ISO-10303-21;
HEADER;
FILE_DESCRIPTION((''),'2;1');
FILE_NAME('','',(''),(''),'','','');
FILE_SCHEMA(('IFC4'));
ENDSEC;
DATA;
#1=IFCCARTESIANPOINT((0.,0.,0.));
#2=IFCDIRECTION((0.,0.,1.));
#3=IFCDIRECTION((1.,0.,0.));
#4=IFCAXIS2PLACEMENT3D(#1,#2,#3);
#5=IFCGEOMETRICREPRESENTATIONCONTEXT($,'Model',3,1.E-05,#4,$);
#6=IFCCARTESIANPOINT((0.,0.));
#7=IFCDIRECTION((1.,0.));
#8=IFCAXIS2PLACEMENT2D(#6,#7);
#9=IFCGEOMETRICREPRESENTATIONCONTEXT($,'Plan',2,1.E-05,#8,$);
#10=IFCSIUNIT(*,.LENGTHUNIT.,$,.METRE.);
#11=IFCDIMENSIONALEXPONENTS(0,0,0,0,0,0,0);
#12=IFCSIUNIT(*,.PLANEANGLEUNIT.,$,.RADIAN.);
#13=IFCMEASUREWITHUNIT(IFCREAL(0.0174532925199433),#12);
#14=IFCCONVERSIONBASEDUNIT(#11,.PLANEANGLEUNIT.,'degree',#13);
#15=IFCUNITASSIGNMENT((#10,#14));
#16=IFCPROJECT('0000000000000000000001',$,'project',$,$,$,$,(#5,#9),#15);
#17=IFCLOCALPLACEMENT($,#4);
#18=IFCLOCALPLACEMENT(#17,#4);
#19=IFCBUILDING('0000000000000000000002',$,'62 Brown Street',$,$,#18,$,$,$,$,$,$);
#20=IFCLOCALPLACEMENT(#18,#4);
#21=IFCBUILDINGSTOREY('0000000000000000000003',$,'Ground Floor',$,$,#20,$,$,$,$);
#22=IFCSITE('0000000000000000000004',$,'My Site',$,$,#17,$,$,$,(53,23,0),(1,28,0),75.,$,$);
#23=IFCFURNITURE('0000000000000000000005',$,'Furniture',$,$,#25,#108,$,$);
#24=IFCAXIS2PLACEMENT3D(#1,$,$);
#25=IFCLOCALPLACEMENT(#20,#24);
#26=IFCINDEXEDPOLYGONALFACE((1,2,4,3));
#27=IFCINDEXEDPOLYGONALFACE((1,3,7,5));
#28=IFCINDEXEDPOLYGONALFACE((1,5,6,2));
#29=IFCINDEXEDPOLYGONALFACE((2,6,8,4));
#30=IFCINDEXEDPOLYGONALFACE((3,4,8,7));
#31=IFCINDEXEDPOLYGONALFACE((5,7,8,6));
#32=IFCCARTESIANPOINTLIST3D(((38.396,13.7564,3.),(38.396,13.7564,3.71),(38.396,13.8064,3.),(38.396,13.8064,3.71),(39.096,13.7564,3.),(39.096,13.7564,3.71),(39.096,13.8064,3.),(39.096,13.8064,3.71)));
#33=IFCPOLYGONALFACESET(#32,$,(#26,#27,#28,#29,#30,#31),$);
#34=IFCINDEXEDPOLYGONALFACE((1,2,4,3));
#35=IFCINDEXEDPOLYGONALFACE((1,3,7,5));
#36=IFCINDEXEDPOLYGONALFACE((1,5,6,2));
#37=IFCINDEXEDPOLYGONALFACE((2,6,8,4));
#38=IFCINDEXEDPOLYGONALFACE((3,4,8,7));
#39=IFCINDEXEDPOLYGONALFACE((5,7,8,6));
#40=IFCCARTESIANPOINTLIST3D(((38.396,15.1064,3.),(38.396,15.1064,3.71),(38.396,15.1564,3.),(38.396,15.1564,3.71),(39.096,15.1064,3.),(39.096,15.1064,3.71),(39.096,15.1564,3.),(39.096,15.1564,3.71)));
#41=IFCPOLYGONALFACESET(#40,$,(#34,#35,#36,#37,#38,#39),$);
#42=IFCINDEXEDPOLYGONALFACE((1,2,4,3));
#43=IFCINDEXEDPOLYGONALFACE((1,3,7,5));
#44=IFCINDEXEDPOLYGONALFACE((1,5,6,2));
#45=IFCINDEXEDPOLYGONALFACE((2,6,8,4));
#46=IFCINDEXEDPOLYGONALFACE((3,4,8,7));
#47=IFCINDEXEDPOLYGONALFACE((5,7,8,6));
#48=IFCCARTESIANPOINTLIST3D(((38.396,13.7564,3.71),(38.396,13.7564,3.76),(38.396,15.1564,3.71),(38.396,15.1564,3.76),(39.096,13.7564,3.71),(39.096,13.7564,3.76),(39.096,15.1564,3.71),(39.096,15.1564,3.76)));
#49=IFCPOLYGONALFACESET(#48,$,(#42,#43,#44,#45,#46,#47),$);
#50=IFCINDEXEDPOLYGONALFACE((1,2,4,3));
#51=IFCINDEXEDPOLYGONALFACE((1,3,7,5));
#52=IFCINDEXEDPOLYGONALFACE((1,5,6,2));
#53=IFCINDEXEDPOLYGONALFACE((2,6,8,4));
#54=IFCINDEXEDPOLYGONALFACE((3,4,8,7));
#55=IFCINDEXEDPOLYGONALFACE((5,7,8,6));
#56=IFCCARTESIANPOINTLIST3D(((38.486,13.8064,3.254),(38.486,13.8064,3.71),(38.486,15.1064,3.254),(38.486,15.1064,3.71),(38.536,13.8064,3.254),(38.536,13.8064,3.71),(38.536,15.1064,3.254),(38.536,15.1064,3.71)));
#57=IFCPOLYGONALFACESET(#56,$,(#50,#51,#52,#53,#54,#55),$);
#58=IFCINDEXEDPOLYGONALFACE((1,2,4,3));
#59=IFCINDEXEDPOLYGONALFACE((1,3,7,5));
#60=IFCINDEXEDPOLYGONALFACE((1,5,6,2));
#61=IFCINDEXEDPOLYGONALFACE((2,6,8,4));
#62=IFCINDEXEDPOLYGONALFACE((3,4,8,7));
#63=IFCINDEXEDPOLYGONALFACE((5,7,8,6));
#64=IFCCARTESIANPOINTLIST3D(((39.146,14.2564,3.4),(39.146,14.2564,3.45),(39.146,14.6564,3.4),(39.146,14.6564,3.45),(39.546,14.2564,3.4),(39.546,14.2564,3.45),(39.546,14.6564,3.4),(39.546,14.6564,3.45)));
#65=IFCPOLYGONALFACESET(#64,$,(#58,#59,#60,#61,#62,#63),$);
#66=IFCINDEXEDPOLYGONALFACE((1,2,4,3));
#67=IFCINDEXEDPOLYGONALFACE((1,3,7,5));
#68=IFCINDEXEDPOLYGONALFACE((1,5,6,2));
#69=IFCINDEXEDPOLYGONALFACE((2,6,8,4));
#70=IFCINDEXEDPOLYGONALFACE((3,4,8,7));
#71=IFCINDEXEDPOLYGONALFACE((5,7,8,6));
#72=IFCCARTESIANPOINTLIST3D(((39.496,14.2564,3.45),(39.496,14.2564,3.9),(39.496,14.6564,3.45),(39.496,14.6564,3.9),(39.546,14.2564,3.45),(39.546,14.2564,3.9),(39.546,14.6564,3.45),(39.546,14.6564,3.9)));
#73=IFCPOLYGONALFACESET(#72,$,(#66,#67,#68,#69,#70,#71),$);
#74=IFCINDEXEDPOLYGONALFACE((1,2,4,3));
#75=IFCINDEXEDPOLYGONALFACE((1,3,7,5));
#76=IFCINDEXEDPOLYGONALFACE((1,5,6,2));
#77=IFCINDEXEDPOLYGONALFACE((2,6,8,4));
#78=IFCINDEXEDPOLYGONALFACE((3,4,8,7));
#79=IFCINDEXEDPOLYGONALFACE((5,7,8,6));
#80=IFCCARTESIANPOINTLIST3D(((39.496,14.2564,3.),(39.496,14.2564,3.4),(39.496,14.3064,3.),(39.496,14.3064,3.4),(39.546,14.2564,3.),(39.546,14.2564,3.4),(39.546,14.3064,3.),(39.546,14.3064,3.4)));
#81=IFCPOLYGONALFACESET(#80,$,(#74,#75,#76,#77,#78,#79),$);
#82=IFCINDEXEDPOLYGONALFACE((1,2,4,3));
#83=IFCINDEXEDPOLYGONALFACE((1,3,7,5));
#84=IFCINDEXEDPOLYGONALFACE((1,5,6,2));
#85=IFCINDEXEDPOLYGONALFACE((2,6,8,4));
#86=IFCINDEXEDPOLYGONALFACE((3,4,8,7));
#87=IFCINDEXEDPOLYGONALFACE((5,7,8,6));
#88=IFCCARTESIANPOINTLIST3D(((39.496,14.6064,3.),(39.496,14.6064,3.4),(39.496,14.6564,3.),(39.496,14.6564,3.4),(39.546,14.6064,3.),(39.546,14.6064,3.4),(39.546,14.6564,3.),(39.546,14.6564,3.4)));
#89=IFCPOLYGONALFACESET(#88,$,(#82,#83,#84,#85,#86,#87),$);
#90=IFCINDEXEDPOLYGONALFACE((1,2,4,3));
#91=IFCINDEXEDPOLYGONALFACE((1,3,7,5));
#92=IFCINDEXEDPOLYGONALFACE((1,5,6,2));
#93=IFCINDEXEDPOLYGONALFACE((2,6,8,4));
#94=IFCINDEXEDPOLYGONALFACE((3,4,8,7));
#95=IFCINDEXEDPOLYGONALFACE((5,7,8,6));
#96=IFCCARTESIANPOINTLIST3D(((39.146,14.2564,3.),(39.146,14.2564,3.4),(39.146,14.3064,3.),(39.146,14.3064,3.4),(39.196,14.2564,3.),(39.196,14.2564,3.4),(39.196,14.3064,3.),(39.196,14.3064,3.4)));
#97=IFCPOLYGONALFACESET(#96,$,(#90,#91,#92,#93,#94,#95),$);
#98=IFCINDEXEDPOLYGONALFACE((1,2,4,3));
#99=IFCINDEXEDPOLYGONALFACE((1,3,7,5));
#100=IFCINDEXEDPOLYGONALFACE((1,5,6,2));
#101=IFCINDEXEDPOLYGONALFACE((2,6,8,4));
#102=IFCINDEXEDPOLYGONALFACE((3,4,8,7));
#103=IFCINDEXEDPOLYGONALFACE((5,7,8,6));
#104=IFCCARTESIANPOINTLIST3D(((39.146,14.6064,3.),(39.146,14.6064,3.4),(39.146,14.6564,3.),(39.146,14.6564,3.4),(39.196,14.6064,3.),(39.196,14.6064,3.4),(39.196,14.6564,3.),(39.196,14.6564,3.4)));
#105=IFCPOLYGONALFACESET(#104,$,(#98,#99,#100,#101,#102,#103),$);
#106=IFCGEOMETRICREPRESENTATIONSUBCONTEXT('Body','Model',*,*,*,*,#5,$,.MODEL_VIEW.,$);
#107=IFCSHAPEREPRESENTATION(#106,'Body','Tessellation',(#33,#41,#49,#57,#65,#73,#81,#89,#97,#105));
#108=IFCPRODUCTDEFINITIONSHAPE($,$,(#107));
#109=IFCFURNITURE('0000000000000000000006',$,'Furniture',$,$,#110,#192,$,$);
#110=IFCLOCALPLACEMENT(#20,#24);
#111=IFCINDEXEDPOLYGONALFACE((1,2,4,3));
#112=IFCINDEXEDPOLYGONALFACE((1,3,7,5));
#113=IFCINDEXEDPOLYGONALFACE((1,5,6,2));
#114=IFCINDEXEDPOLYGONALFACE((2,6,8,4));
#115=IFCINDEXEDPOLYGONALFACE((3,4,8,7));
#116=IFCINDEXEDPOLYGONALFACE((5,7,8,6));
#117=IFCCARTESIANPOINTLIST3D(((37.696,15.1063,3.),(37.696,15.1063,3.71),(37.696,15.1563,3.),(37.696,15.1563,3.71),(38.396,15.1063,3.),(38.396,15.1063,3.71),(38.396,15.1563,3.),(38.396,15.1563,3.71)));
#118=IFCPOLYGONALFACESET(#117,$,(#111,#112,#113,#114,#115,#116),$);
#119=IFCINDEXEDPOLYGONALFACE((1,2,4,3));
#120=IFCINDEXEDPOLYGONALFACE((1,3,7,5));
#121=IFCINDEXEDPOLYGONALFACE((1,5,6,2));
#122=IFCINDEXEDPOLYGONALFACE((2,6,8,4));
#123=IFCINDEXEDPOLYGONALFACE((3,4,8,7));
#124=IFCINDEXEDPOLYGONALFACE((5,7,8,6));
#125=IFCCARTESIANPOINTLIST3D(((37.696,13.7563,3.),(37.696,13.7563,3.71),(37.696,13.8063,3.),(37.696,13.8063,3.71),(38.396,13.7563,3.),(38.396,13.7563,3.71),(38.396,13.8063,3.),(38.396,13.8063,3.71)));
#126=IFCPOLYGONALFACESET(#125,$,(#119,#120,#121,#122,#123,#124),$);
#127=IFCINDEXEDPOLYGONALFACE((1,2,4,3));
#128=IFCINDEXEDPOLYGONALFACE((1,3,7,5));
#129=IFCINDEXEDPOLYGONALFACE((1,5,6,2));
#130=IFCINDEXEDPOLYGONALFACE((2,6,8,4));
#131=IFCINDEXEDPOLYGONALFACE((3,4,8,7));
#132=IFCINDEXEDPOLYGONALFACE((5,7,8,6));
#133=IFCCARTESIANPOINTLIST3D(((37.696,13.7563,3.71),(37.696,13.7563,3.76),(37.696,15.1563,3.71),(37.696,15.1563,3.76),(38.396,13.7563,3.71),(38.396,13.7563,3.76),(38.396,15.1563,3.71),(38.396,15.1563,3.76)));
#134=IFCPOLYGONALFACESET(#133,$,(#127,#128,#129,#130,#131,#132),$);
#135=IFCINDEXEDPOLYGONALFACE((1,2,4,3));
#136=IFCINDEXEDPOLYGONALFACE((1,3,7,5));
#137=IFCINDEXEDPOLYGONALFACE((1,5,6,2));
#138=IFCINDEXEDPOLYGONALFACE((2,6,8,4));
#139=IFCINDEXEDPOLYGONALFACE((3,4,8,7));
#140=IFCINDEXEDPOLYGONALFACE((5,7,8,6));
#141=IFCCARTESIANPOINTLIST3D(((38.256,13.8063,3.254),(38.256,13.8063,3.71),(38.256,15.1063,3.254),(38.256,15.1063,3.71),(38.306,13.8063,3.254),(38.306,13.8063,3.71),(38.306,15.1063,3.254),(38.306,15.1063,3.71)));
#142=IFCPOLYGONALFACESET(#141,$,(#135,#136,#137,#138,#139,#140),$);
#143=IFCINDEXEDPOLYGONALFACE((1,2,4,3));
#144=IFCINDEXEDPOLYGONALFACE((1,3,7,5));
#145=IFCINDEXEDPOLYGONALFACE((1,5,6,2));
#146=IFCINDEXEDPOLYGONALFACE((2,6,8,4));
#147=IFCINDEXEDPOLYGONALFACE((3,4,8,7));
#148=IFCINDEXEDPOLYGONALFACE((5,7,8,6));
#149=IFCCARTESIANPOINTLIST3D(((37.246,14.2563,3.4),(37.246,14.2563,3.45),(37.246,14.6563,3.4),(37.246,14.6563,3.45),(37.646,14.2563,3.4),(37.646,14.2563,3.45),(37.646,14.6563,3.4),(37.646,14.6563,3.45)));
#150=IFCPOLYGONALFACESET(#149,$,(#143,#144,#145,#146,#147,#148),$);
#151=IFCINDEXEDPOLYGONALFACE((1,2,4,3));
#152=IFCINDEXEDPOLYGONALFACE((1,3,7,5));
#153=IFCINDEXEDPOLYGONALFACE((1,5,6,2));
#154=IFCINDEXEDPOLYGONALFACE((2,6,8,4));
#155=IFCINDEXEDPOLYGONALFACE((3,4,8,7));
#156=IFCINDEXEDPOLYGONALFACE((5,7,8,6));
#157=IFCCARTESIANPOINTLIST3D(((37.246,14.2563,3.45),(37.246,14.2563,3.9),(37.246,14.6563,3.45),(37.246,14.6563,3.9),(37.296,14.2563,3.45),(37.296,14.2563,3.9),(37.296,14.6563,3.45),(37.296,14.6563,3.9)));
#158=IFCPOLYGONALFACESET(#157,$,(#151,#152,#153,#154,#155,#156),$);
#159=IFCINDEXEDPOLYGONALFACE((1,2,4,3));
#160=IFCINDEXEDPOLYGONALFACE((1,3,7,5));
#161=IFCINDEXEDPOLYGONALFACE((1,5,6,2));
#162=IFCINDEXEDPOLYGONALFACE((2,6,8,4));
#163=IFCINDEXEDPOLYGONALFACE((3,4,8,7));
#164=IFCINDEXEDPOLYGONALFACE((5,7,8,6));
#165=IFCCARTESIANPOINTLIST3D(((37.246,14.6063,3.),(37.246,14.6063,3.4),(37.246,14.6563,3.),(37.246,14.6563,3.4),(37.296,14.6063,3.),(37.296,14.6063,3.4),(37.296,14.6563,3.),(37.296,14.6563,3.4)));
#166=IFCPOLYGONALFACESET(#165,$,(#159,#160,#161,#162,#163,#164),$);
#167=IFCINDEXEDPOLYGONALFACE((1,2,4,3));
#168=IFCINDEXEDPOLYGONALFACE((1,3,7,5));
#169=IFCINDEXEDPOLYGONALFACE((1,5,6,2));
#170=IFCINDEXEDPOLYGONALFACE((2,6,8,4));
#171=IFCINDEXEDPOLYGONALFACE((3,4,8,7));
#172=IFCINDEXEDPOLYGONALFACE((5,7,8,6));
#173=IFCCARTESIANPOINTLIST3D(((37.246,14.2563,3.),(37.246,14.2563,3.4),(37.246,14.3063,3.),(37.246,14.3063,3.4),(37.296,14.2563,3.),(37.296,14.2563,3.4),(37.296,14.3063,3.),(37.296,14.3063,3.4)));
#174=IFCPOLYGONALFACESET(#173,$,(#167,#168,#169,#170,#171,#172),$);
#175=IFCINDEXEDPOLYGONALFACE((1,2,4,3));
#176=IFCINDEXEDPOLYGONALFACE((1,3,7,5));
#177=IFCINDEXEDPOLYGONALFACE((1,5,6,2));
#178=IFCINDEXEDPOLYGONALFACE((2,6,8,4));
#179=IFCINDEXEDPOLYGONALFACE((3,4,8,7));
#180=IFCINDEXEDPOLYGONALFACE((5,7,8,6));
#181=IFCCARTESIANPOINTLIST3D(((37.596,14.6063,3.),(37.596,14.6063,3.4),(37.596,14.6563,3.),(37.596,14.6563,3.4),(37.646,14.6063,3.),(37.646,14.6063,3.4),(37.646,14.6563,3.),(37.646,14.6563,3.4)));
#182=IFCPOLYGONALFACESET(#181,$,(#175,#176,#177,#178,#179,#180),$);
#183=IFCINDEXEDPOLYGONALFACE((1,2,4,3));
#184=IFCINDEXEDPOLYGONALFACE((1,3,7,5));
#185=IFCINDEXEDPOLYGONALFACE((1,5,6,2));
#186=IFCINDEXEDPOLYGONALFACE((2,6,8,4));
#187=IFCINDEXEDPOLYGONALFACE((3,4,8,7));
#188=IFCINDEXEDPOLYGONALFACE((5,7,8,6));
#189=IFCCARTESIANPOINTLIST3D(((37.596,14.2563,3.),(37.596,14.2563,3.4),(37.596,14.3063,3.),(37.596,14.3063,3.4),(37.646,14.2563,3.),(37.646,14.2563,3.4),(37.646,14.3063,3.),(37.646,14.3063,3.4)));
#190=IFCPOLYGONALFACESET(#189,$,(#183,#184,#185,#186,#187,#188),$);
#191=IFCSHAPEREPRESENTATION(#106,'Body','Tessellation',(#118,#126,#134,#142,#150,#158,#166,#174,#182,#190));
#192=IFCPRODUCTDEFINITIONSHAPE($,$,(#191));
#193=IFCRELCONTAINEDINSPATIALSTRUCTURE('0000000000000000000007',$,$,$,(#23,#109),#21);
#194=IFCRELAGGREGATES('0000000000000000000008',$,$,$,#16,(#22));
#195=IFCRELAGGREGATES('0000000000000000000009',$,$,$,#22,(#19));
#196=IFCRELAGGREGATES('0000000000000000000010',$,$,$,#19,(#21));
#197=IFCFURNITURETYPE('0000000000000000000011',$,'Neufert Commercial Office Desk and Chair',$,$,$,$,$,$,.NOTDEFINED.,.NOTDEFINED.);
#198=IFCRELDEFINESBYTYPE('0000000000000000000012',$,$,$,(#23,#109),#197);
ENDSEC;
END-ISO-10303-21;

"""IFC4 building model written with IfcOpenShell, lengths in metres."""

from ifc_helpers import new_model, entity, si_unit, converted_unit, frame, origin_with_axes, origin_2d_with_axis, place, context, subcontext, project, spatial, line, indexed_curve, outline, extrude, shape, source, transform, mapped, type_object, type_shapes, element, save


model = new_model("IFC4")

# Units and contexts
model_context = context("Model", 3, precision=1e-05, world=origin_with_axes())
plan_context = context("Plan", 2, precision=1e-05, world=origin_2d_with_axis())
body_context_1 = subcontext(model_context, "Body", "Model", "MODEL_VIEW")
body_context_2 = subcontext(plan_context, "Body", "Plan", "PLAN_VIEW")
ifc_project = project(units=[si_unit("LENGTHUNIT", "METRE"), converted_unit("PLANEANGLEUNIT", "degree", entity("IfcReal", 0.0174532925199433), si_unit("PLANEANGLEUNIT", "RADIAN"), dimensions=[0, 0, 0, 0, 0, 0, 0])], contexts=[model_context, plan_context])

# Site, building, storey
site_placement = place(None, origin_with_axes())
site = spatial("IfcSite", under=ifc_project, at=site_placement, Name="My Site", RefLatitude=(53, 23, 0), RefLongitude=(1, 28, 0), RefElevation=75.0)
building_placement = place(site_placement, origin_with_axes())
building = spatial("IfcBuilding", under=site, at=building_placement, Name="62 Brown Street")
storey_placement = place(building_placement, origin_with_axes())
storey = spatial("IfcBuildingStorey", under=building, at=storey_placement, Name="Ground Floor")

# Furniture
furniture_type = type_object("IfcFurnitureType", Name="Neufert Commercial Office Desk and Chair", AssemblyPlace="NOTDEFINED", PredefinedType="NOTDEFINED")
shared_shape_1 = source(origin_with_axes(), body_context_1, "Body", "SweptSolid", [
    extrude(outline(indexed_curve([(0.0, 0.0), (0.05, 0.0), (0.05, 0.7), (0.0, 0.7)], segments=[line(1, 2, 3, 4, 1)])), frame((0.0, 0.45, 0.0), z_axis=(0.0, 0.0, 1.0), x_axis=(1.0, 0.0, 0.0)), (0.0, 0.0, 1.0), 0.71),
    extrude(outline(indexed_curve([(0.0, 0.0), (0.05, 0.0), (0.05, 0.7), (0.0, 0.7)], segments=[line(1, 2, 3, 4, 1)])), frame((1.35, 0.45, 0.0), z_axis=(0.0, 0.0, 1.0), x_axis=(1.0, 0.0, 0.0)), (0.0, 0.0, 1.0), 0.71),
    extrude(outline(indexed_curve([(0.0, 0.0), (1.4, 0.0), (1.4, 0.7), (0.0, 0.7)], segments=[line(1, 2, 3, 4, 1)])), frame((0.0, 0.45, 0.71), z_axis=(0.0, 0.0, 1.0), x_axis=(1.0, 0.0, 0.0)), (0.0, 0.0, 1.0), 0.05),
    extrude(outline(indexed_curve([(0.05, 0.56), (1.35, 0.56), (1.35, 0.61), (0.05, 0.61)], segments=[line(1, 2, 3, 4, 1)])), frame((0.0, 0.45, 0.254), z_axis=(0.0, 0.0, 1.0), x_axis=(1.0, 0.0, 0.0)), (0.0, 0.0, 1.0), 0.456),
    extrude(outline(indexed_curve([(-0.2, 0.0), (0.2, 0.0), (0.2, 0.4), (-0.2, 0.4)], segments=[line(1, 2, 3, 4, 1)])), frame((0.7, 0.0, 0.45), z_axis=(0.0, 0.0, 1.0), x_axis=(1.0, 0.0, 0.0)), (0.0, 0.0, -1.0), 0.05),
    extrude(outline(indexed_curve([(-0.2, 0.0), (0.2, 0.0), (0.2, 0.05), (-0.2, 0.05)], segments=[line(1, 2, 3, 4, 1)])), frame((0.7, 0.0, 0.9), z_axis=(0.0, 0.0, 1.0), x_axis=(1.0, 0.0, 0.0)), (0.0, 0.0, -1.0), 0.45),
    extrude(outline(indexed_curve([(-0.2, 0.0), (-0.15, 0.0), (-0.15, 0.05), (-0.2, 0.05)], segments=[line(1, 2, 3, 4, 1)])), frame((0.7, 0.0, 0.0), z_axis=(0.0, 0.0, 1.0), x_axis=(1.0, 0.0, 0.0)), (0.0, 0.0, 1.0), 0.4),
    extrude(outline(indexed_curve([(0.2, 0.0), (0.15, 0.0), (0.15, 0.05), (0.2, 0.05)], segments=[line(1, 2, 3, 4, 1)])), frame((0.7, 0.0, 0.0), z_axis=(0.0, 0.0, 1.0), x_axis=(1.0, 0.0, 0.0)), (0.0, 0.0, 1.0), 0.4),
    extrude(outline(indexed_curve([(-0.2, 0.4), (-0.15, 0.4), (-0.15, 0.35), (-0.2, 0.35)], segments=[line(1, 2, 3, 4, 1)])), frame((0.7, 0.0, 0.0), z_axis=(0.0, 0.0, 1.0), x_axis=(1.0, 0.0, 0.0)), (0.0, 0.0, 1.0), 0.4),
    extrude(outline(indexed_curve([(0.2, 0.4), (0.15, 0.4), (0.15, 0.35), (0.2, 0.35)], segments=[line(1, 2, 3, 4, 1)])), frame((0.7, 0.0, 0.0), z_axis=(0.0, 0.0, 1.0), x_axis=(1.0, 0.0, 0.0)), (0.0, 0.0, 1.0), 0.4),
])
shared_shape_2 = source(origin_with_axes(), body_context_2, "Body", "Curve2D", [
    entity("IfcIndexedPolyCurve", entity("IfcCartesianPointList2D", [[0.0, 0.45], [1.4, 0.45], [1.4, 1.15], [0.0, 1.15]]), [entity("IfcLineIndex", [1, 2, 3, 4, 1])]),
    entity("IfcIndexedPolyCurve", entity("IfcCartesianPointList2D", [[0.5, 0.4], [0.9, 0.4]])),
    entity("IfcIndexedPolyCurve", entity("IfcCartesianPointList2D", [[0.5, 0.4], [0.5, 0.2], [0.5586, 0.0586], [0.7, 0.0], [0.8414, 0.0586], [0.9, 0.2], [0.9, 0.4]]), [entity("IfcLineIndex", [1, 2]), entity("IfcArcIndex", [2, 3, 4]), entity("IfcArcIndex", [4, 5, 6]), entity("IfcLineIndex", [6, 7])]),
    entity("IfcIndexedPolyCurve", entity("IfcCartesianPointList2D", [[0.54, 0.4], [0.54, 0.2], [0.5869, 0.0869], [0.7, 0.04], [0.8131, 0.0869], [0.86, 0.2], [0.86, 0.4]]), [entity("IfcLineIndex", [1, 2]), entity("IfcArcIndex", [2, 3, 4]), entity("IfcArcIndex", [4, 5, 6]), entity("IfcLineIndex", [6, 7])]),
])
type_shapes(furniture_type, [shared_shape_1, shared_shape_2])
for number, where, z_axis, x_axis, name in (
    (1, (39.546, 13.7564, 3.0), (0.0, 0.0, 1.0), (0.0, 1.0, 0.0), "Furniture"),
    (2, (37.246, 15.1563, 3.0), (0.0, 0.0, 1.0), (0.0, -1.0, 0.0), "Furniture"),
):
    element("IfcFurniture", number, at=place(storey_placement, frame(where, z_axis=z_axis, x_axis=x_axis)), inside=storey, type_object=furniture_type, Name=name, shapes=[
        shape(body_context_1, "Body", "MappedRepresentation", [mapped(shared_shape_1, transform((0.0, 0.0, 0.0), x_axis=(1.0, 0.0, 0.0), y_axis=(0.0, 1.0, 0.0), z_axis=(0.0, 0.0, 1.0), scale=1.0))]),
        shape(body_context_2, "Body", "MappedRepresentation", [mapped(shared_shape_2, transform((0.0, 0.0, 0.0), x_axis=(1.0, 0.0, 0.0), y_axis=(0.0, 1.0, 0.0), z_axis=(0.0, 0.0, 1.0), scale=1.0))]),
    ])

save(model, "model.ifc")
